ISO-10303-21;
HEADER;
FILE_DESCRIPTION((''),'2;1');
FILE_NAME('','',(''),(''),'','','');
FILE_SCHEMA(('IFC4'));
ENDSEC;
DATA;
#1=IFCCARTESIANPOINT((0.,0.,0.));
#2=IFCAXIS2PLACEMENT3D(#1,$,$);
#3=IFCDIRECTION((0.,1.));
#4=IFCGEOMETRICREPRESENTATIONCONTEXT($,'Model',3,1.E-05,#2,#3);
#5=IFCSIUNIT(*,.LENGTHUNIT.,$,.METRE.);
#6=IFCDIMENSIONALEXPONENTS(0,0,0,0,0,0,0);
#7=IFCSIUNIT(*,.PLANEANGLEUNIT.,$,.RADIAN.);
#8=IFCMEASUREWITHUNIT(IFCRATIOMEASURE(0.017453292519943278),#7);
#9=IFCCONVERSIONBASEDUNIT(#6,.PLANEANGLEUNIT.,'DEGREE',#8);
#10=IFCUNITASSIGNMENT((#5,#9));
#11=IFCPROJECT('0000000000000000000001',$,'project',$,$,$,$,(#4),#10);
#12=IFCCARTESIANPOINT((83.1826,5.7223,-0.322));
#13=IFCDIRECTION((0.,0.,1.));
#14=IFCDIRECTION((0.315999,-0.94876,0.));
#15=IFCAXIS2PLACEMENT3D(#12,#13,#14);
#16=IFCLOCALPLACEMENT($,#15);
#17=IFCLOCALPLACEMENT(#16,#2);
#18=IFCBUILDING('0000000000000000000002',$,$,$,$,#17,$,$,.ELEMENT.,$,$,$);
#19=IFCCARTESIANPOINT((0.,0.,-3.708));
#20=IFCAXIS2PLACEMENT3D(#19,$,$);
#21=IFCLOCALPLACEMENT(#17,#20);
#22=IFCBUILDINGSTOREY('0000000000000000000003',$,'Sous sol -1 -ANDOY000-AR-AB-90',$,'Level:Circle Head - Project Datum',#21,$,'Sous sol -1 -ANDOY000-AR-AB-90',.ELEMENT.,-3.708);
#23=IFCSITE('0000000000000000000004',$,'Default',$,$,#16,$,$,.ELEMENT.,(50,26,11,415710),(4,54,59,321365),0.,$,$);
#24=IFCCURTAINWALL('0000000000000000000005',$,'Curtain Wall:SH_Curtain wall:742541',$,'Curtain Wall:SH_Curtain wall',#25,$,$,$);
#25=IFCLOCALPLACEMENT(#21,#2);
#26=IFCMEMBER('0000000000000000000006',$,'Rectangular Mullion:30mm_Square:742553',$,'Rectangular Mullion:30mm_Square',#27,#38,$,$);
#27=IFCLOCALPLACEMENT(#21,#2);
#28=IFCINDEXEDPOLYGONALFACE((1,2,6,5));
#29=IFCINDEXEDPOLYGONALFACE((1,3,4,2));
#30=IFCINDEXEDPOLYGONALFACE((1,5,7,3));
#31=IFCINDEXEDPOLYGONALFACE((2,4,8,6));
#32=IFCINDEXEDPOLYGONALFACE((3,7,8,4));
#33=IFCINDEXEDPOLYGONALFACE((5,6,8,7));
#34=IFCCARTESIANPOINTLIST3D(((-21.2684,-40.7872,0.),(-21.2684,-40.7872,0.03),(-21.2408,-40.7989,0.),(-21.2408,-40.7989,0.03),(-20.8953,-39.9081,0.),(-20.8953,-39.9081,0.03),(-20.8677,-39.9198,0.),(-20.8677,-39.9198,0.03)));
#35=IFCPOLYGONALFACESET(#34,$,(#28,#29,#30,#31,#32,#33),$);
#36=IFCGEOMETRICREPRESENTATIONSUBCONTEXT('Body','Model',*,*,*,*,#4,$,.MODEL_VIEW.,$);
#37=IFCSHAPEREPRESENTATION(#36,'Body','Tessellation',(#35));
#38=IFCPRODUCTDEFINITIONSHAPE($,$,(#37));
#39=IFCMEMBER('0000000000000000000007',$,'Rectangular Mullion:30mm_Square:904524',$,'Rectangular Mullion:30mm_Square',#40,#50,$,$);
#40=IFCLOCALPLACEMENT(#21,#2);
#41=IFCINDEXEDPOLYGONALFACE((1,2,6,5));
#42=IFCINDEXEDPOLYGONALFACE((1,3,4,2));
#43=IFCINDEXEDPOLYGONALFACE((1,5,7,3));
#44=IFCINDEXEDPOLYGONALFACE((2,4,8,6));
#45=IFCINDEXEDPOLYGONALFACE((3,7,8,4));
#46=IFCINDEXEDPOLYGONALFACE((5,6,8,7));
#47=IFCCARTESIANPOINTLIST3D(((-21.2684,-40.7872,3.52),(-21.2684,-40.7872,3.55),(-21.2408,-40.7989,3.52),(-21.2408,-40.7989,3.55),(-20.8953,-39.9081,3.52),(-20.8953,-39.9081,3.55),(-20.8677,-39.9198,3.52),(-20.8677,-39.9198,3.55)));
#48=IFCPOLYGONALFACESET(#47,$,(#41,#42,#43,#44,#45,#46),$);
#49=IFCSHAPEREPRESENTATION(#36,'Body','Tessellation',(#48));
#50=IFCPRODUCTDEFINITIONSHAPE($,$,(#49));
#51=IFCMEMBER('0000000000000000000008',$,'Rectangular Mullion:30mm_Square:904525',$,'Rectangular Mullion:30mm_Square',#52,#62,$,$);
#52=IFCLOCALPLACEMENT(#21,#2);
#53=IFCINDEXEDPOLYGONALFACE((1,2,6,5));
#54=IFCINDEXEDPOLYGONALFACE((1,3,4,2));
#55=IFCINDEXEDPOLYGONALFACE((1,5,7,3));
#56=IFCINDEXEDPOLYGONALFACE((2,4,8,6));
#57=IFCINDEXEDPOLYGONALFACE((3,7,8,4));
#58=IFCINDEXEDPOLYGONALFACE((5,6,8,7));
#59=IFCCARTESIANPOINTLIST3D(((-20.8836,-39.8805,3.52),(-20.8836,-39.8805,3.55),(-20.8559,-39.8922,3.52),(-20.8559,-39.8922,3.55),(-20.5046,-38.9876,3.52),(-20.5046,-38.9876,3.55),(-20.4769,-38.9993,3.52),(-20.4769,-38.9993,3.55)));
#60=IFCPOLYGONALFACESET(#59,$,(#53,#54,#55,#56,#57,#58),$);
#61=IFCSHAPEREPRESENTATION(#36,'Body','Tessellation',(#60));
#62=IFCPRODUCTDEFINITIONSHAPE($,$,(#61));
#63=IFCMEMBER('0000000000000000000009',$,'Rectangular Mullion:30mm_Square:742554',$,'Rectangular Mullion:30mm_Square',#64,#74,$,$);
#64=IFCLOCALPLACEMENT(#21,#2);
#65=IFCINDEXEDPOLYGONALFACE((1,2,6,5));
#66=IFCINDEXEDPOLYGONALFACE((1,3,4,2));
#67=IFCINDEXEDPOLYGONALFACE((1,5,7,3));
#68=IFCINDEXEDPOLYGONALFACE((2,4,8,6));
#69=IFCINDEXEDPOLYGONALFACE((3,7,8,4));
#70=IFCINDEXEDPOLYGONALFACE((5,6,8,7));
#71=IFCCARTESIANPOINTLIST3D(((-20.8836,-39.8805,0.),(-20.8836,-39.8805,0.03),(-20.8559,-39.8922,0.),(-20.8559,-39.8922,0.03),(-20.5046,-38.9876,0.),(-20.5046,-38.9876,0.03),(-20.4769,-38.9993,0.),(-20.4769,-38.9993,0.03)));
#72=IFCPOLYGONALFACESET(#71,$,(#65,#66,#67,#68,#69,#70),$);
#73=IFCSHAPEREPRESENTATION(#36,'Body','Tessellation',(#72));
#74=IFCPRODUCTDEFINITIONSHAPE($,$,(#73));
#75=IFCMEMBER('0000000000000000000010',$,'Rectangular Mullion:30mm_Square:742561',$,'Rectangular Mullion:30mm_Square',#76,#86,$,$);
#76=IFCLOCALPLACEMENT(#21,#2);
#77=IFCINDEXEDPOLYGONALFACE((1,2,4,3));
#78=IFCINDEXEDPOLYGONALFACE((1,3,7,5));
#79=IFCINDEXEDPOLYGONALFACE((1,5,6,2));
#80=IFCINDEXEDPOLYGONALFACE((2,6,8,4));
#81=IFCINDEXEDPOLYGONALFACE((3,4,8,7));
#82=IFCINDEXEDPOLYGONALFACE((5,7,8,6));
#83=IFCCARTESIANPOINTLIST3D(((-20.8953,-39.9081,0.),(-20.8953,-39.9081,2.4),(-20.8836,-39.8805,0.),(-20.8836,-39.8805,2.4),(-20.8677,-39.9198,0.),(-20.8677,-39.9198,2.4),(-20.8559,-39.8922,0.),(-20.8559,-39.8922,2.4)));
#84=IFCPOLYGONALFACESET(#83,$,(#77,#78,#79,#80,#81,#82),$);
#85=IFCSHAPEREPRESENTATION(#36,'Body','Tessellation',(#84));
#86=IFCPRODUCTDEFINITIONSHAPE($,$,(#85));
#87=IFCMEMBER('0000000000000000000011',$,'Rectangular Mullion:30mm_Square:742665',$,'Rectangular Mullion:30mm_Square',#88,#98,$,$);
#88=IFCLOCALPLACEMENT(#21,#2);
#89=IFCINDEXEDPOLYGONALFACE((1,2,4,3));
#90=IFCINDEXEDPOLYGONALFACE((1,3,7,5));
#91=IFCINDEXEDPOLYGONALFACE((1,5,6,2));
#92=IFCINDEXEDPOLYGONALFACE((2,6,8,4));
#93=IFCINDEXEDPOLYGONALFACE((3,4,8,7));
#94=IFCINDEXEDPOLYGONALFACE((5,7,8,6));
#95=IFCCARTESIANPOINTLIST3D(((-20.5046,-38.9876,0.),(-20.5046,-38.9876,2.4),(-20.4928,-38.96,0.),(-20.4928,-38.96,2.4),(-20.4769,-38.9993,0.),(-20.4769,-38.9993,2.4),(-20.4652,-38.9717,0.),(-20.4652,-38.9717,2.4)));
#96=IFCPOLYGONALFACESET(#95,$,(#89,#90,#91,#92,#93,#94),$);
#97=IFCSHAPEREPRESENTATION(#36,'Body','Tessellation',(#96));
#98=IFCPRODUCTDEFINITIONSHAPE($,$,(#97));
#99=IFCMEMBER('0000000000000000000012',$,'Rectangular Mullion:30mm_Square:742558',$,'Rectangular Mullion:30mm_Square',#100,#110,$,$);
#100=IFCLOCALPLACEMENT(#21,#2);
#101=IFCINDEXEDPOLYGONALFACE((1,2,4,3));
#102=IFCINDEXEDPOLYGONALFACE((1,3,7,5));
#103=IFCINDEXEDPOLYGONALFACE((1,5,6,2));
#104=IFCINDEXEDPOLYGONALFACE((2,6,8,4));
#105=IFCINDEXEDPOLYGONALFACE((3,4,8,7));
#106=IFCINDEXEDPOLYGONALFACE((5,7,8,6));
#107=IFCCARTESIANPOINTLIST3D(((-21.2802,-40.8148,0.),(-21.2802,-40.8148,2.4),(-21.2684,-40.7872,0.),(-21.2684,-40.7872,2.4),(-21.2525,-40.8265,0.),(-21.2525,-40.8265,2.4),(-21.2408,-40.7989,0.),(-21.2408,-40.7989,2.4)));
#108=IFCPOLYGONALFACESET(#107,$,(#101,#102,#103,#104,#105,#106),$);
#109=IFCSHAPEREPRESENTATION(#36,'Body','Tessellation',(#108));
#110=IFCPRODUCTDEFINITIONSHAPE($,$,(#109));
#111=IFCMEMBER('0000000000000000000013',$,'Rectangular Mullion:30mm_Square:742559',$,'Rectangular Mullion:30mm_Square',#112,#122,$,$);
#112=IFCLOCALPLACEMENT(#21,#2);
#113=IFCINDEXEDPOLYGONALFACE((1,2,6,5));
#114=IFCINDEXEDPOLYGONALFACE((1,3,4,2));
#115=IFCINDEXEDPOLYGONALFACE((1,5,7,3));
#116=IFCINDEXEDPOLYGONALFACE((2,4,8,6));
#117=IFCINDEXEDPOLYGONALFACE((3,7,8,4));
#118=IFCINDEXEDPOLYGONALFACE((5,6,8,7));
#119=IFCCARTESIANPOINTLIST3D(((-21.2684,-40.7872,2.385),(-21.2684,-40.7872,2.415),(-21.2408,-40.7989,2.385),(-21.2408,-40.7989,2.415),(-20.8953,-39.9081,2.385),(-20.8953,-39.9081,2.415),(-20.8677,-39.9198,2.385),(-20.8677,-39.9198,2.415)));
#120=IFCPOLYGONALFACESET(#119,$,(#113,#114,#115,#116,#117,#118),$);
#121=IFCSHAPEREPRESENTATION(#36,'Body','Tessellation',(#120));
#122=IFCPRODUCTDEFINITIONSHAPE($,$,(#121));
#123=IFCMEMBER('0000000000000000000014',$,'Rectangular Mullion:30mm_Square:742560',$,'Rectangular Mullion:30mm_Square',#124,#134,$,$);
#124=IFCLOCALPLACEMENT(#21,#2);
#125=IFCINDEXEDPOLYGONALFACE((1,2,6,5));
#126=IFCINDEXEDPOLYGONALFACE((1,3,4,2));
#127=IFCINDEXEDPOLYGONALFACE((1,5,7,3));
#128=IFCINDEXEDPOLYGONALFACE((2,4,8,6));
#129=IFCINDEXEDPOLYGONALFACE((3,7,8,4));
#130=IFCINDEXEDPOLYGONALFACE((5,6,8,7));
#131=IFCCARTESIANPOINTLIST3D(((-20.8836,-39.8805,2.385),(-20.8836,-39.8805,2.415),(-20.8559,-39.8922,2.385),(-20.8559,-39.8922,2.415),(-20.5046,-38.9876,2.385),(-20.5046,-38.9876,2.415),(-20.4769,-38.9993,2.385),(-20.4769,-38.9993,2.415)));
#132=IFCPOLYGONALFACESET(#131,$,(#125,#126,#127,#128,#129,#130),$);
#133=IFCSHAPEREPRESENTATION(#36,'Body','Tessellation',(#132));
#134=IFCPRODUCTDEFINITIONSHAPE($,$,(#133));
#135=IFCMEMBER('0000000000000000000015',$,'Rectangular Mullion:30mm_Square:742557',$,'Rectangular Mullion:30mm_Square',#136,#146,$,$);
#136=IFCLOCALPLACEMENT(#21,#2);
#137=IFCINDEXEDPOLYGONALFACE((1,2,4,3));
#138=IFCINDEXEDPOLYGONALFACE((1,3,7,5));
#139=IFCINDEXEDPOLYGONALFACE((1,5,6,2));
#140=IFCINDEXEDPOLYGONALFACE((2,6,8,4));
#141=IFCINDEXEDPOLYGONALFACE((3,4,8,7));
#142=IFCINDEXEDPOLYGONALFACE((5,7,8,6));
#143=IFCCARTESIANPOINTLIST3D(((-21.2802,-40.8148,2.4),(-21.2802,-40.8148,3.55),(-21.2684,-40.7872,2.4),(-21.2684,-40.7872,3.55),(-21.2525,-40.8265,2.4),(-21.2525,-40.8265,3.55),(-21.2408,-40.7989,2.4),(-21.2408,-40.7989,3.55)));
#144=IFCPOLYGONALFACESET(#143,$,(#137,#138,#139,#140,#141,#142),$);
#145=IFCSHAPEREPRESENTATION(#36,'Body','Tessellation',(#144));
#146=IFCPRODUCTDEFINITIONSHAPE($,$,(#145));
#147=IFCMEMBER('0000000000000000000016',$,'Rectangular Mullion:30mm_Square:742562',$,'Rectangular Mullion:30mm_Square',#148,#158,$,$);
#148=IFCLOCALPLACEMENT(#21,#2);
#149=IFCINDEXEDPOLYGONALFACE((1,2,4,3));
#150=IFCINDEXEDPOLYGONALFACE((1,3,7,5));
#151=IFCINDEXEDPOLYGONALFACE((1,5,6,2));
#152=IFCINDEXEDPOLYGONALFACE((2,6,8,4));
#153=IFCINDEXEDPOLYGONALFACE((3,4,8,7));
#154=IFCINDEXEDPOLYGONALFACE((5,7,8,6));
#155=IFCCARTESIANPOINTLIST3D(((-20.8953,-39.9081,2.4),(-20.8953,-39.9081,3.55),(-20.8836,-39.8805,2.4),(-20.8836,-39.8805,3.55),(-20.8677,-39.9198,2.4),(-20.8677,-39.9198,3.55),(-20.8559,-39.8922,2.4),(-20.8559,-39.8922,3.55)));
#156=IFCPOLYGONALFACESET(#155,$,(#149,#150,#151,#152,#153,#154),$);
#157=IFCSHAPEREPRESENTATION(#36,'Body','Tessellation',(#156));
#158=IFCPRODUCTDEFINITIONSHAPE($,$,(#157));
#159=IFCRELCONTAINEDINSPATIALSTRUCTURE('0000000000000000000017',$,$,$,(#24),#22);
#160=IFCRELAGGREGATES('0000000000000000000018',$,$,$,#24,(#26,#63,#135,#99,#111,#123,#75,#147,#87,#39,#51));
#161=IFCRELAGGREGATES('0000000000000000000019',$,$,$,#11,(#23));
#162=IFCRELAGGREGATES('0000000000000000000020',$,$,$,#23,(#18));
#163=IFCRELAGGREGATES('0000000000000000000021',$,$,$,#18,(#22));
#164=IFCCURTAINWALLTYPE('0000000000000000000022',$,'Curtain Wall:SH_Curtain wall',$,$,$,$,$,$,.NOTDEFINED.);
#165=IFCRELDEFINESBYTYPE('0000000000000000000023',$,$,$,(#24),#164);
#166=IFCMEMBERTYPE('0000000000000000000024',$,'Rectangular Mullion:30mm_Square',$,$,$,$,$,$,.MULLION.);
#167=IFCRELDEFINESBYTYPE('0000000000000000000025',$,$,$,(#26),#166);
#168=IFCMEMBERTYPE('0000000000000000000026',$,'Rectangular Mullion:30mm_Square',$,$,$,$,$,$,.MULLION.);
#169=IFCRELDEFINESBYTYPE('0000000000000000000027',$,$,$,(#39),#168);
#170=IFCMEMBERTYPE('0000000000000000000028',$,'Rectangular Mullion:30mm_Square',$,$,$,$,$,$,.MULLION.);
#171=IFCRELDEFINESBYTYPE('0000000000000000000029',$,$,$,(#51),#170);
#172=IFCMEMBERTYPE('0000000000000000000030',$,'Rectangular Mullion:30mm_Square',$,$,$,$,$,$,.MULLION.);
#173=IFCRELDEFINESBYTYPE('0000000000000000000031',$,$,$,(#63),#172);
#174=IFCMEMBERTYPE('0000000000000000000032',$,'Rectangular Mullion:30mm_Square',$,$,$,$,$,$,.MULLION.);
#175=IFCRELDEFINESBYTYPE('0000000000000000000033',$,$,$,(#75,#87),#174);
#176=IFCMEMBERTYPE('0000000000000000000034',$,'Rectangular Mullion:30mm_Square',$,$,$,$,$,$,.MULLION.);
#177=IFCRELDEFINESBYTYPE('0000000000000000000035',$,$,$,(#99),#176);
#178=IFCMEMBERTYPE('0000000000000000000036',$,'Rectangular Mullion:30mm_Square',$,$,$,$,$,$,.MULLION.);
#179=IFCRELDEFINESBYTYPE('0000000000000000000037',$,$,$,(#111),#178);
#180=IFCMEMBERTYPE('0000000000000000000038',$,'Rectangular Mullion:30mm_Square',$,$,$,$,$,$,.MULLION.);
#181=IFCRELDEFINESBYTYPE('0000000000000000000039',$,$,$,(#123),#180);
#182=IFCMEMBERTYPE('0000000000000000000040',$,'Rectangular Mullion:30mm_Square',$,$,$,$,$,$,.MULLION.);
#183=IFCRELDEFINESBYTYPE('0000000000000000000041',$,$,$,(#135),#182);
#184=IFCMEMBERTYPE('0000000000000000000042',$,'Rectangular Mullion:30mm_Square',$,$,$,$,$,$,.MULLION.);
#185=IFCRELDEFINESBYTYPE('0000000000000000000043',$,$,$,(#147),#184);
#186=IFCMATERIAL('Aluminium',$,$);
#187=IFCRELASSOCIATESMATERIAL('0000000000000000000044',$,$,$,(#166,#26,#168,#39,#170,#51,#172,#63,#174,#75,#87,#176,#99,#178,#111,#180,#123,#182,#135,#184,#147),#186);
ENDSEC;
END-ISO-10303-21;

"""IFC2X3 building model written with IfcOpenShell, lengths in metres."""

from ifc_helpers import new_model, entity, si_unit, converted_unit, direction, frame, origin, origin_2d_with_axis, place, context, subcontext, project, spatial, rectangle, extrude, source, transform, mapped, material, type_object, type_shapes, element, aggregate, save


model = new_model("IFC2X3")

# Units and contexts
model_context = context("Model", 3, precision=1e-05, world=origin(), true_north=direction((0.0, 1.0)))
body_context = subcontext(model_context, "Body", "Model", "MODEL_VIEW")
ifc_project = project(units=[si_unit("LENGTHUNIT", "METRE"), converted_unit("PLANEANGLEUNIT", "DEGREE", entity("IfcRatioMeasure", 0.017453292519943278), si_unit("PLANEANGLEUNIT", "RADIAN"), dimensions=[0, 0, 0, 0, 0, 0, 0])], contexts=[model_context])

# Site, building, storey
site_placement = place(None, frame((83.1826, 5.7223, -0.322), z_axis=(0.0, 0.0, 1.0), x_axis=(0.315999, -0.94876, 0.0)))
site = spatial("IfcSite", under=ifc_project, at=site_placement, Name="Default", CompositionType="ELEMENT", RefLatitude=(50, 26, 11, 415710), RefLongitude=(4, 54, 59, 321365), RefElevation=0.0)
building_placement = place(site_placement, origin())
building = spatial("IfcBuilding", under=site, at=building_placement, CompositionType="ELEMENT")
storey_placement = place(building_placement, frame((0.0, 0.0, -3.708)))
storey = spatial("IfcBuildingStorey", under=building, at=storey_placement, Name="Sous sol -1 -ANDOY000-AR-AB-90", ObjectType="Level:Circle Head - Project Datum", LongName="Sous sol -1 -ANDOY000-AR-AB-90", CompositionType="ELEMENT", Elevation=-3.708)

# Curtain wall, members
curtain_wall_type = type_object("IfcCurtainWallType", Name="Curtain Wall:SH_Curtain wall", PredefinedType="NOTDEFINED")
curtain_wall_placement = place(storey_placement, frame((0.0, 0.0, 3.708)))
curtain_wall = element("IfcCurtainWall", 1, at=curtain_wall_placement, inside=storey, type_object=curtain_wall_type, Name="Curtain Wall:SH_Curtain wall:742541", ObjectType="Curtain Wall:SH_Curtain wall")
ifc_material_1 = material(Name="Aluminium")
member_type_1 = type_object("IfcMemberType", Name="Rectangular Mullion:30mm_Square", PredefinedType="MULLION", material=ifc_material_1)
shared_shape_1 = source(origin(), body_context, "Body", "SweptSolid", [
    extrude(rectangle(XDim=0.03, YDim=0.03, at=origin_2d_with_axis()), frame((-0.015, 0.0, -0.955), z_axis=(0.0, 0.0, 1.0), x_axis=(0.0, -1.0, 0.0)), (0.0, 0.0, 1.0), 0.955),
])
type_shapes(member_type_1, [shared_shape_1])
member_1_placement = place(curtain_wall_placement, frame((-21.2546, -40.793, -3.708), z_axis=(-0.390731, -0.920505, 0.0), x_axis=(0.0, 0.0, -1.0)))
member_1 = element("IfcMember", 2, at=member_1_placement, type_object=member_type_1, material=ifc_material_1, Name="Rectangular Mullion:30mm_Square:742553", ObjectType="Rectangular Mullion:30mm_Square", context=body_context, shape_type="MappedRepresentation", body=[
    mapped(shared_shape_1, transform((0.0, 0.0, 0.0), scale=1.0)),
])
member_type_2 = type_object("IfcMemberType", Name="Rectangular Mullion:30mm_Square", PredefinedType="MULLION", material=ifc_material_1)
shared_shape_2 = source(origin(), body_context, "Body", "SweptSolid", [
    extrude(rectangle(XDim=0.03, YDim=0.03, at=origin_2d_with_axis()), frame((-0.015, 0.0, -0.955), z_axis=(0.0, 0.0, 1.0), x_axis=(0.0, -1.0, 0.0)), (0.0, 0.0, 1.0), 0.955),
])
type_shapes(member_type_2, [shared_shape_2])
member_2_placement = place(curtain_wall_placement, frame((-20.8815, -39.914, -0.158), z_axis=(0.390731, 0.920505, 0.0), x_axis=(0.0, 0.0, 1.0)))
member_2 = element("IfcMember", 3, at=member_2_placement, type_object=member_type_2, material=ifc_material_1, Name="Rectangular Mullion:30mm_Square:904524", ObjectType="Rectangular Mullion:30mm_Square", context=body_context, shape_type="MappedRepresentation", body=[
    mapped(shared_shape_2, transform((0.0, 0.0, 0.0), scale=1.0)),
])
member_type_3 = type_object("IfcMemberType", Name="Rectangular Mullion:30mm_Square", PredefinedType="MULLION", material=ifc_material_1)
shared_shape_3 = source(origin(), body_context, "Body", "SweptSolid", [
    extrude(rectangle(XDim=0.03, YDim=0.03, at=origin_2d_with_axis()), frame((-0.015, 0.0, -0.97), z_axis=(0.0, 0.0, 1.0), x_axis=(0.0, -1.0, 0.0)), (0.0, 0.0, 1.0), 0.97),
])
type_shapes(member_type_3, [shared_shape_3])
member_3_placement = place(curtain_wall_placement, frame((-20.4907, -38.9935, -0.158), z_axis=(0.390731, 0.920505, 0.0), x_axis=(0.0, 0.0, 1.0)))
member_3 = element("IfcMember", 4, at=member_3_placement, type_object=member_type_3, material=ifc_material_1, Name="Rectangular Mullion:30mm_Square:904525", ObjectType="Rectangular Mullion:30mm_Square", context=body_context, shape_type="MappedRepresentation", body=[
    mapped(shared_shape_3, transform((0.0, 0.0, 0.0), scale=1.0)),
])
member_type_4 = type_object("IfcMemberType", Name="Rectangular Mullion:30mm_Square", PredefinedType="MULLION", material=ifc_material_1)
shared_shape_4 = source(origin(), body_context, "Body", "SweptSolid", [
    extrude(rectangle(XDim=0.03, YDim=0.03, at=origin_2d_with_axis()), frame((-0.015, 0.0, -0.97), z_axis=(0.0, 0.0, 1.0), x_axis=(0.0, -1.0, 0.0)), (0.0, 0.0, 1.0), 0.97),
])
type_shapes(member_type_4, [shared_shape_4])
member_4_placement = place(curtain_wall_placement, frame((-20.8698, -39.8863, -3.708), z_axis=(-0.390731, -0.920505, 0.0), x_axis=(0.0, 0.0, -1.0)))
member_4 = element("IfcMember", 5, at=member_4_placement, type_object=member_type_4, material=ifc_material_1, Name="Rectangular Mullion:30mm_Square:742554", ObjectType="Rectangular Mullion:30mm_Square", context=body_context, shape_type="MappedRepresentation", body=[
    mapped(shared_shape_4, transform((0.0, 0.0, 0.0), scale=1.0)),
])
member_type_5 = type_object("IfcMemberType", Name="Rectangular Mullion:30mm_Square", PredefinedType="MULLION", material=ifc_material_1)
shared_shape_5 = source(origin(), body_context, "Body", "SweptSolid", [
    extrude(rectangle(XDim=0.03, YDim=0.03, at=origin_2d_with_axis()), frame((0.0, 0.0, -2.4), z_axis=(0.0, 0.0, 1.0), x_axis=(0.0, -1.0, 0.0)), (0.0, 0.0, 1.0), 2.4),
])
type_shapes(member_type_5, [shared_shape_5])
member_5_placement = place(curtain_wall_placement, frame((-20.8756, -39.9002, -3.708), z_axis=(0.0, 0.0, -1.0), x_axis=(0.390731, 0.920505, 0.0)))
member_5 = element("IfcMember", 6, at=member_5_placement, type_object=member_type_5, material=ifc_material_1, Name="Rectangular Mullion:30mm_Square:742561", ObjectType="Rectangular Mullion:30mm_Square", context=body_context, shape_type="MappedRepresentation", body=[
    mapped(shared_shape_5, transform((0.0, 0.0, 0.0), scale=1.0)),
])
member_6_placement = place(curtain_wall_placement, frame((-20.4849, -38.9796, -3.708), z_axis=(0.0, 0.0, -1.0), x_axis=(0.390731, 0.920505, 0.0)))
member_6 = element("IfcMember", 7, at=member_6_placement, type_object=member_type_5, material=ifc_material_1, Name="Rectangular Mullion:30mm_Square:742665", ObjectType="Rectangular Mullion:30mm_Square", context=body_context, shape_type="MappedRepresentation", body=[
    mapped(shared_shape_5, transform((0.0, 0.0, 0.0), scale=1.0)),
])
member_type_6 = type_object("IfcMemberType", Name="Rectangular Mullion:30mm_Square", PredefinedType="MULLION", material=ifc_material_1)
shared_shape_6 = source(origin(), body_context, "Body", "SweptSolid", [
    extrude(rectangle(XDim=0.03, YDim=0.03, at=origin_2d_with_axis()), frame((-0.015, 0.0, -2.4), z_axis=(0.0, 0.0, 1.0), x_axis=(0.0, -1.0, 0.0)), (0.0, 0.0, 1.0), 2.4),
])
type_shapes(member_type_6, [shared_shape_6])
member_7_placement = place(curtain_wall_placement, frame((-21.2663, -40.8207, -1.308), z_axis=(0.0, 0.0, 1.0), x_axis=(-0.390731, -0.920505, 0.0)))
member_7 = element("IfcMember", 8, at=member_7_placement, type_object=member_type_6, material=ifc_material_1, Name="Rectangular Mullion:30mm_Square:742558", ObjectType="Rectangular Mullion:30mm_Square", context=body_context, shape_type="MappedRepresentation", body=[
    mapped(shared_shape_6, transform((0.0, 0.0, 0.0), scale=1.0)),
])
member_type_7 = type_object("IfcMemberType", Name="Rectangular Mullion:30mm_Square", PredefinedType="MULLION", material=ifc_material_1)
shared_shape_7 = source(origin(), body_context, "Body", "SweptSolid", [
    extrude(rectangle(XDim=0.03, YDim=0.03, at=origin_2d_with_axis()), frame((0.0, 0.0, -0.955), z_axis=(0.0, 0.0, 1.0), x_axis=(0.0, -1.0, 0.0)), (0.0, 0.0, 1.0), 0.955),
])
type_shapes(member_type_7, [shared_shape_7])
member_8_placement = place(curtain_wall_placement, frame((-20.8815, -39.914, -1.308), z_axis=(0.390731, 0.920505, 0.0), x_axis=(0.0, 0.0, 1.0)))
member_8 = element("IfcMember", 9, at=member_8_placement, type_object=member_type_7, material=ifc_material_1, Name="Rectangular Mullion:30mm_Square:742559", ObjectType="Rectangular Mullion:30mm_Square", context=body_context, shape_type="MappedRepresentation", body=[
    mapped(shared_shape_7, transform((0.0, 0.0, 0.0), scale=1.0)),
])
member_type_8 = type_object("IfcMemberType", Name="Rectangular Mullion:30mm_Square", PredefinedType="MULLION", material=ifc_material_1)
shared_shape_8 = source(origin(), body_context, "Body", "SweptSolid", [
    extrude(rectangle(XDim=0.03, YDim=0.03, at=origin_2d_with_axis()), frame((0.0, 0.0, -0.97), z_axis=(0.0, 0.0, 1.0), x_axis=(0.0, -1.0, 0.0)), (0.0, 0.0, 1.0), 0.97),
])
type_shapes(member_type_8, [shared_shape_8])
member_9_placement = place(curtain_wall_placement, frame((-20.4907, -38.9935, -1.308), z_axis=(0.390731, 0.920505, 0.0), x_axis=(0.0, 0.0, 1.0)))
member_9 = element("IfcMember", 10, at=member_9_placement, type_object=member_type_8, material=ifc_material_1, Name="Rectangular Mullion:30mm_Square:742560", ObjectType="Rectangular Mullion:30mm_Square", context=body_context, shape_type="MappedRepresentation", body=[
    mapped(shared_shape_8, transform((0.0, 0.0, 0.0), scale=1.0)),
])
member_type_9 = type_object("IfcMemberType", Name="Rectangular Mullion:30mm_Square", PredefinedType="MULLION", material=ifc_material_1)
shared_shape_9 = source(origin(), body_context, "Body", "SweptSolid", [
    extrude(rectangle(XDim=0.03, YDim=0.03, at=origin_2d_with_axis()), frame((-0.015, 0.0, -1.15), z_axis=(0.0, 0.0, 1.0), x_axis=(0.0, -1.0, 0.0)), (0.0, 0.0, 1.0), 1.15),
])
type_shapes(member_type_9, [shared_shape_9])
member_10_placement = place(curtain_wall_placement, frame((-21.2663, -40.8207, -0.158), z_axis=(0.0, 0.0, 1.0), x_axis=(-0.390731, -0.920505, 0.0)))
member_10 = element("IfcMember", 11, at=member_10_placement, type_object=member_type_9, material=ifc_material_1, Name="Rectangular Mullion:30mm_Square:742557", ObjectType="Rectangular Mullion:30mm_Square", context=body_context, shape_type="MappedRepresentation", body=[
    mapped(shared_shape_9, transform((0.0, 0.0, 0.0), scale=1.0)),
])
member_type_10 = type_object("IfcMemberType", Name="Rectangular Mullion:30mm_Square", PredefinedType="MULLION", material=ifc_material_1)
shared_shape_10 = source(origin(), body_context, "Body", "SweptSolid", [
    extrude(rectangle(XDim=0.03, YDim=0.03, at=origin_2d_with_axis()), frame((0.0, 0.0, -1.15), z_axis=(0.0, 0.0, 1.0), x_axis=(0.0, -1.0, 0.0)), (0.0, 0.0, 1.0), 1.15),
])
type_shapes(member_type_10, [shared_shape_10])
member_11_placement = place(curtain_wall_placement, frame((-20.8756, -39.9002, -1.308), z_axis=(0.0, 0.0, -1.0), x_axis=(0.390731, 0.920505, 0.0)))
member_11 = element("IfcMember", 12, at=member_11_placement, type_object=member_type_10, material=ifc_material_1, Name="Rectangular Mullion:30mm_Square:742562", ObjectType="Rectangular Mullion:30mm_Square", context=body_context, shape_type="MappedRepresentation", body=[
    mapped(shared_shape_10, transform((0.0, 0.0, 0.0), scale=1.0)),
])
aggregate(curtain_wall, [member_1, member_4, member_10, member_7, member_8, member_9, member_5, member_11, member_6, member_2, member_3])

save(model, "model.ifc")
